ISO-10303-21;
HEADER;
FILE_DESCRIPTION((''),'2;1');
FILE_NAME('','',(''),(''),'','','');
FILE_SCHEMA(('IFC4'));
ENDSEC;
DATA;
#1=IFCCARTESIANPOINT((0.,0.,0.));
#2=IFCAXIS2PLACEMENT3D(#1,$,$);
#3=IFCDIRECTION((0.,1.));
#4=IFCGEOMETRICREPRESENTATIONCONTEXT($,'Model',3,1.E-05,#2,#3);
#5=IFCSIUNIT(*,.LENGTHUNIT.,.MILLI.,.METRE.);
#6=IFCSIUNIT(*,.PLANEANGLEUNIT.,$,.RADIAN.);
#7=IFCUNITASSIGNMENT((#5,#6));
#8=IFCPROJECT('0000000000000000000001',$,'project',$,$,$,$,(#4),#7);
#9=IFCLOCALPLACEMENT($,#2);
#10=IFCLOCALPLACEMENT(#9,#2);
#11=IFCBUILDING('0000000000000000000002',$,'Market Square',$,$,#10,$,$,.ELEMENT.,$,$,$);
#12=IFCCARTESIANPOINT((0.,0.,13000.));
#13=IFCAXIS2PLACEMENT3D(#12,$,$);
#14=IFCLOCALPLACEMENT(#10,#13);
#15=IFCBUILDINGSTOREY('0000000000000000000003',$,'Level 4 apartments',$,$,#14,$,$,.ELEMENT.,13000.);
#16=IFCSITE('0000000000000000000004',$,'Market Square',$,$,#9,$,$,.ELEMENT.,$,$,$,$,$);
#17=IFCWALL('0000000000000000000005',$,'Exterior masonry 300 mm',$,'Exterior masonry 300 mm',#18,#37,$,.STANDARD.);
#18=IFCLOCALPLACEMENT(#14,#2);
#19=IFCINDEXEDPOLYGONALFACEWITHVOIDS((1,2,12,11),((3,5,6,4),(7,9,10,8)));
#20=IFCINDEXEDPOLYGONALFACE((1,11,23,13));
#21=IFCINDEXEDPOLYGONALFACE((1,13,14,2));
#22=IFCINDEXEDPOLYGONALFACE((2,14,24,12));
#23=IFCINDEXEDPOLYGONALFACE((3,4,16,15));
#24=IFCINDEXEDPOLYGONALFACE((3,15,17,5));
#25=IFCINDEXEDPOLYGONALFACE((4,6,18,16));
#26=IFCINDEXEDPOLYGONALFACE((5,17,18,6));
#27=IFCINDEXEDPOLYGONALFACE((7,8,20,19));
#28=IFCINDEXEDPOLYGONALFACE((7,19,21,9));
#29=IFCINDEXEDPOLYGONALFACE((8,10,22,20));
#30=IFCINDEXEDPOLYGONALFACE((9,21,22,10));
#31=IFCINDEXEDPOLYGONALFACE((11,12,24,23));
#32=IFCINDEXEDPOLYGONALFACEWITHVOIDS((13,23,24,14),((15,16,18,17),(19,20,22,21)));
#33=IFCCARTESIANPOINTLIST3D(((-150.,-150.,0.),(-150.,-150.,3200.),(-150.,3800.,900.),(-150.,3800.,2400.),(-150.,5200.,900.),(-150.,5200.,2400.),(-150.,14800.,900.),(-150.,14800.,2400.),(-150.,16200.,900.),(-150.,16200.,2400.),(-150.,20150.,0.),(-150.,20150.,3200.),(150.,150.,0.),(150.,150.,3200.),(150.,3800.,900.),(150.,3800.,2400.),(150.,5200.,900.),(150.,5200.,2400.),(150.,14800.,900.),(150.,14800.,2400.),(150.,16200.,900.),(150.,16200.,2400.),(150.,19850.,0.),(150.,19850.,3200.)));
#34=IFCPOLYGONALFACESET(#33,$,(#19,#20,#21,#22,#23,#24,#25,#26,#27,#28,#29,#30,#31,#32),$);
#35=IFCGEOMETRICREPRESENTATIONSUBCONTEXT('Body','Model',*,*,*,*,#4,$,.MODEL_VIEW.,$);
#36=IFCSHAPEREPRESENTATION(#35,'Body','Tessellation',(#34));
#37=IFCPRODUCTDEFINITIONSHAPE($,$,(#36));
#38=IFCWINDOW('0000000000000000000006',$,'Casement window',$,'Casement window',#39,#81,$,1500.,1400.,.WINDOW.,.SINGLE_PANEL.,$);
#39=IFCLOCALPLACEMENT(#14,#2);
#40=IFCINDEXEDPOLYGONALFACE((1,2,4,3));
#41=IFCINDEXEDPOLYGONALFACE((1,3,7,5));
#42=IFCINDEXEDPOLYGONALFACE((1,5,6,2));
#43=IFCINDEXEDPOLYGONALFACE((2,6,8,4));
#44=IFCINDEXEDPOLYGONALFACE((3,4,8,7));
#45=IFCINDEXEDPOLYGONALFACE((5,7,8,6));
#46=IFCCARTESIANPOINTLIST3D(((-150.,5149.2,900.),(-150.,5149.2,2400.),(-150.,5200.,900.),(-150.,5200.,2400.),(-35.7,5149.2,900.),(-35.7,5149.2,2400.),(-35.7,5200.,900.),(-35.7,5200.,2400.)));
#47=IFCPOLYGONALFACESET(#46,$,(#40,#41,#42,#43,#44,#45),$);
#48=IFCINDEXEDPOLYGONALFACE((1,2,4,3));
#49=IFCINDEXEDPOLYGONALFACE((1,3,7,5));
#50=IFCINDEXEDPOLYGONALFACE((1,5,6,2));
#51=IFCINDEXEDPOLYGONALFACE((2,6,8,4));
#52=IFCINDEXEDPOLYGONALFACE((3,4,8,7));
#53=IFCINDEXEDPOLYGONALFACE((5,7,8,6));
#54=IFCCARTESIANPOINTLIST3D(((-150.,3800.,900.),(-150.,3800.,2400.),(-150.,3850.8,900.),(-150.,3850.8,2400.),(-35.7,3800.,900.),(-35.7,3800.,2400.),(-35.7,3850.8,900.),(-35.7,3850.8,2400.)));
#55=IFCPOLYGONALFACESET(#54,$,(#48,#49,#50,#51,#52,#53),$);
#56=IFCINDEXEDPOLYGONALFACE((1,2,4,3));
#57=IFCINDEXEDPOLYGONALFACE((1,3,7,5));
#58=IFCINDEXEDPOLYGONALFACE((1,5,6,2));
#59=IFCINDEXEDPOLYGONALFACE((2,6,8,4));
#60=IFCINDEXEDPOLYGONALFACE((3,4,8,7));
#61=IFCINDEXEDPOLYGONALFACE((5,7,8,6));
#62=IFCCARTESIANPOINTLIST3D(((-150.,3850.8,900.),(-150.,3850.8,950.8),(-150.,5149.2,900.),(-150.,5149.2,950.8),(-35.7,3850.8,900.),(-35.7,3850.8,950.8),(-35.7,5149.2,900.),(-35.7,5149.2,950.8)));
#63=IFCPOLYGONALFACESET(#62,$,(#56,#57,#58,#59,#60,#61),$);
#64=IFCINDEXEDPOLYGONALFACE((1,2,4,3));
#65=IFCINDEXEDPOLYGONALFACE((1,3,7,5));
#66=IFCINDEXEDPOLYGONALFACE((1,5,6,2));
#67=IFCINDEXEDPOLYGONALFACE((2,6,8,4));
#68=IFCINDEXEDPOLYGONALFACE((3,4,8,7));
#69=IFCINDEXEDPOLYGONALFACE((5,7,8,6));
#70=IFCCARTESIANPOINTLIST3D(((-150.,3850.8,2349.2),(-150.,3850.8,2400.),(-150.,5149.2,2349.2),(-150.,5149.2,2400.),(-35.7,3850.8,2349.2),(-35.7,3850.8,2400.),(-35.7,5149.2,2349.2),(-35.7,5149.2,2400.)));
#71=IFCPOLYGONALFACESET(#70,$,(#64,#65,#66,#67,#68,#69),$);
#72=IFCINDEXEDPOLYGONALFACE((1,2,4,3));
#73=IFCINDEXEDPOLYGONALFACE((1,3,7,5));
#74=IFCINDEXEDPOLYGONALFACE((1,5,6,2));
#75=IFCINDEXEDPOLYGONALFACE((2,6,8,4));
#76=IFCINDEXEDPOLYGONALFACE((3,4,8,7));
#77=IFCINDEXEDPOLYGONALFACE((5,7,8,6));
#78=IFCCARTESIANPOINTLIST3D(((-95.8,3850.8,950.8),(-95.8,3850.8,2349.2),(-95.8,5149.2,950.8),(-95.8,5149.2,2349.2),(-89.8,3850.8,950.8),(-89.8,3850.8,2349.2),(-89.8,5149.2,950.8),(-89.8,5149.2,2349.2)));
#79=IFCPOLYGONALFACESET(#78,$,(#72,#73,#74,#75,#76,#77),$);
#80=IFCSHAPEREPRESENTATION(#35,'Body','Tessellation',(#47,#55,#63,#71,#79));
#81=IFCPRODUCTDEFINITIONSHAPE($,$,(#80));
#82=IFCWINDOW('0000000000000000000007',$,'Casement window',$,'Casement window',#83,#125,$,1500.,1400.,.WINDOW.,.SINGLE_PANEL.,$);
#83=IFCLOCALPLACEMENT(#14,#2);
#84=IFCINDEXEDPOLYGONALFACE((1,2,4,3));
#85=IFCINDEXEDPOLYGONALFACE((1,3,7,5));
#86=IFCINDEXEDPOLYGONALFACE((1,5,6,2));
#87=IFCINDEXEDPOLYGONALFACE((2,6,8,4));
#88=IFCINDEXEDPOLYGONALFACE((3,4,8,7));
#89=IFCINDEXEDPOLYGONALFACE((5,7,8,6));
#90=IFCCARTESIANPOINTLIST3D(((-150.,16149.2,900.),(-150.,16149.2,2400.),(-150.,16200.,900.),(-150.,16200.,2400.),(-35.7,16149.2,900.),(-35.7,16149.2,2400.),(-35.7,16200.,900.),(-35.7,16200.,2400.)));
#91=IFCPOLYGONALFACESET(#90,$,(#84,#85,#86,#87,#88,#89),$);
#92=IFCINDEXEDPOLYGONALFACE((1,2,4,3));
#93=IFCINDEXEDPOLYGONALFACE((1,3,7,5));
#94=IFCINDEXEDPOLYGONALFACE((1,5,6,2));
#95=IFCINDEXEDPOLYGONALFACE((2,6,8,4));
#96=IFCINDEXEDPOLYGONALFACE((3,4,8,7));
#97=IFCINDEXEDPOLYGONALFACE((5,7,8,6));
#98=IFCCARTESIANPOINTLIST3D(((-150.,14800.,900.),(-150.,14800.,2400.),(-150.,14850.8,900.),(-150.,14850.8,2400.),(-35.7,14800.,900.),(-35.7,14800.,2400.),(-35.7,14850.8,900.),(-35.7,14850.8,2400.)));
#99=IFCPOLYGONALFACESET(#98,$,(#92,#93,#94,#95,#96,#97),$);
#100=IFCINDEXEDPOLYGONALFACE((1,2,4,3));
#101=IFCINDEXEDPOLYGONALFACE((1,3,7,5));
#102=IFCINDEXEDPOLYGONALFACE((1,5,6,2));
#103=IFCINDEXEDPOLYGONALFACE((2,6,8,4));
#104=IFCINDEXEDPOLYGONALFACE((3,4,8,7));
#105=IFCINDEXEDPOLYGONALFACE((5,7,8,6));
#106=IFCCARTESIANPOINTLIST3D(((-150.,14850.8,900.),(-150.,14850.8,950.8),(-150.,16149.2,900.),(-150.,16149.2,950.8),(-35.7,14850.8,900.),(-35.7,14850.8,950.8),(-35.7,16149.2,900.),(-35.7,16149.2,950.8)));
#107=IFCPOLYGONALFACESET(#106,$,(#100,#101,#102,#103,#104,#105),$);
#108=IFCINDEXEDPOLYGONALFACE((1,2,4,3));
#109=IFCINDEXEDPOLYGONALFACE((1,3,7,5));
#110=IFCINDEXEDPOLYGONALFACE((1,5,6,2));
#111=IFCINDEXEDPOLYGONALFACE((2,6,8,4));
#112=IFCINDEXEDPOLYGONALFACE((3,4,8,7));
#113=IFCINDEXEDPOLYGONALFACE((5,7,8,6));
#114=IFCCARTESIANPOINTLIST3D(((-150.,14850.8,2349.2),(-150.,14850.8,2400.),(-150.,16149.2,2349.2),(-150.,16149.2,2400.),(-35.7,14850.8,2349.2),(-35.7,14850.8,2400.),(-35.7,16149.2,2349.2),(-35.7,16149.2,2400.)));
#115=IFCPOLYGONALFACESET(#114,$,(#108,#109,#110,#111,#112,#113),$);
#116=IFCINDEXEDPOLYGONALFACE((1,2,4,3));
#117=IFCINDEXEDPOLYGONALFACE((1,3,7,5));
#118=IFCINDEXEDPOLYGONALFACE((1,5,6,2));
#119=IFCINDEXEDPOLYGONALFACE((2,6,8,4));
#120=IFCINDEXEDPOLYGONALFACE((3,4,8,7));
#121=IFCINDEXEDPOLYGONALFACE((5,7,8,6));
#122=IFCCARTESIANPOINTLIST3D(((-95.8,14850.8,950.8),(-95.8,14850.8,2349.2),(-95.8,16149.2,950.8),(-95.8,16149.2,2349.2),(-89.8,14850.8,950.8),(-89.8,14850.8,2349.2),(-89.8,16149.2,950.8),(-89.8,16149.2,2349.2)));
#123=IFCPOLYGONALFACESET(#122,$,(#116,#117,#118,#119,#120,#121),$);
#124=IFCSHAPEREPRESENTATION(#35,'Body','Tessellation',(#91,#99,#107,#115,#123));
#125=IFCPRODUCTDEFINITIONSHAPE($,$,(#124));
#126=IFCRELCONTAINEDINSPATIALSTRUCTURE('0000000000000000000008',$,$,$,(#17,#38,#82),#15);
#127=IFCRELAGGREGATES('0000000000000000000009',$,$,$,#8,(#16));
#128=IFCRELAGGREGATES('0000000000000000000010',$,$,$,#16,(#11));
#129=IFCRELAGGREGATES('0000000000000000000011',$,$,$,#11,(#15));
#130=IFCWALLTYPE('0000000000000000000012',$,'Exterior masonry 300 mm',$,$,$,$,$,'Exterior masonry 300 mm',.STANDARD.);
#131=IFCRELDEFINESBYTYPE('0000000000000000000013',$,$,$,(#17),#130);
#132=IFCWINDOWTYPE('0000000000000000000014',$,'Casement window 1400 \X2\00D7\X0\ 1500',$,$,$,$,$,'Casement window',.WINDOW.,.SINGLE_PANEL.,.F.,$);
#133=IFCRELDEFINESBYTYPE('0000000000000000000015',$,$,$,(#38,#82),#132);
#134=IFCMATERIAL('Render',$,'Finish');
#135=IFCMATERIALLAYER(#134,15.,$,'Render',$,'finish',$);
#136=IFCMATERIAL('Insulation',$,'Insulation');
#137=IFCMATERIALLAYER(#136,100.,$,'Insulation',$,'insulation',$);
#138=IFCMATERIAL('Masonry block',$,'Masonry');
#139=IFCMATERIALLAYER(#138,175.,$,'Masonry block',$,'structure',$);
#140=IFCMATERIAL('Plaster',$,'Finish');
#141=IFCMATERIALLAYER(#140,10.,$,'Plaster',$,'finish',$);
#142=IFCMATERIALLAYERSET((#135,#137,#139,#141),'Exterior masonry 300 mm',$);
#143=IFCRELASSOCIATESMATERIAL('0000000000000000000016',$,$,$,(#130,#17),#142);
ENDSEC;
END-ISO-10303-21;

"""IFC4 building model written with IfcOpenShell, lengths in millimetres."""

from ifc_helpers import new_model, si_unit, direction, frame, origin, origin_with_axes, place, context, subcontext, project, spatial, polyline, outline, extrude, material, layer, layer_set, layer_usage, type_object, element, fill, save


model = new_model("IFC4")

# Units and contexts
model_context = context("Model", 3, precision=1e-05, world=origin(), true_north=direction((0.0, 1.0)))
body_context = subcontext(model_context, "Body", "Model", "MODEL_VIEW")
ifc_project = project(units=[si_unit("LENGTHUNIT", "METRE", prefix="MILLI"), si_unit("PLANEANGLEUNIT", "RADIAN")], contexts=[model_context])

# Site, building, storey
site_placement = place(None, origin())
site = spatial("IfcSite", under=ifc_project, at=site_placement, Name="Market Square", CompositionType="ELEMENT")
building_placement = place(site_placement, origin())
building = spatial("IfcBuilding", under=site, at=building_placement, Name="Market Square", CompositionType="ELEMENT")
storey_placement = place(building_placement, frame((0.0, 0.0, 13000.0)))
storey = spatial("IfcBuildingStorey", under=building, at=storey_placement, Name="Level 4 apartments", CompositionType="ELEMENT", Elevation=13000.0)

# Wall, openings, windows
ifc_material_1 = material(Name="Render", Category="Finish")
ifc_layer_1 = layer(ifc_material_1, 15.0, Name="Render", Category="finish")
ifc_material_2 = material(Name="Insulation", Category="Insulation")
ifc_layer_2 = layer(ifc_material_2, 100.0, Name="Insulation", Category="insulation")
ifc_material_3 = material(Name="Masonry block", Category="Masonry")
ifc_layer_3 = layer(ifc_material_3, 175.0, Name="Masonry block", Category="structure")
ifc_material_4 = material(Name="Plaster", Category="Finish")
ifc_layer_4 = layer(ifc_material_4, 10.0, Name="Plaster", Category="finish")
ifc_layer_set_1 = layer_set([ifc_layer_1, ifc_layer_2, ifc_layer_3, ifc_layer_4], Name="Exterior masonry 300 mm")
ifc_layer_usage_1 = layer_usage(ifc_layer_set_1, "AXIS2", "POSITIVE", -150.0)
wall_type_1 = type_object("IfcWallType", Name="Exterior masonry 300 mm", ElementType="Exterior masonry 300 mm", PredefinedType="STANDARD", material=ifc_layer_set_1)
wall_1_placement = place(storey_placement, frame((0.0, 20000.0, 0.0), z_axis=(0.0, 0.0, 1.0), x_axis=(0.0, -1.0, 0.0)))
wall_1 = element("IfcWall", 1, at=wall_1_placement, inside=storey, type_object=wall_type_1, material=ifc_layer_usage_1, Name="Exterior masonry 300 mm", ObjectType="Exterior masonry 300 mm", PredefinedType="STANDARD", context=body_context, shape_type="SweptSolid", body=[
    extrude(outline(polyline([(-150.0, -150.0), (20150.0, -150.0), (19850.0, 150.0), (150.0, 150.0), (-150.0, -150.0)])), origin(), (0.0, 0.0, 1.0), 3200.0),
])
opening_1_placement = place(wall_1_placement, frame((14800.0, 0.0, 900.0), z_axis=(0.0, 0.0, 1.0), x_axis=(1.0, 0.0, 0.0)))
opening_1 = element("IfcOpeningElement", 2, at=opening_1_placement, cuts=wall_1, PredefinedType="OPENING", context=body_context, shape_type="SweptSolid", body=[
    extrude(outline(polyline([(0.0, -160.0), (1400.0, -160.0), (1400.0, 160.0), (0.0, 160.0), (0.0, -160.0)])), origin(), (0.0, 0.0, 1.0), 1500.0),
])
opening_2_placement = place(wall_1_placement, frame((3800.0, 0.0, 900.0), z_axis=(0.0, 0.0, 1.0), x_axis=(1.0, 0.0, 0.0)))
opening_2 = element("IfcOpeningElement", 3, at=opening_2_placement, cuts=wall_1, PredefinedType="OPENING", context=body_context, shape_type="SweptSolid", body=[
    extrude(outline(polyline([(0.0, -160.0), (1400.0, -160.0), (1400.0, 160.0), (0.0, 160.0), (0.0, -160.0)])), origin(), (0.0, 0.0, 1.0), 1500.0),
])
window_type = type_object("IfcWindowType", Name="Casement window 1400 × 1500", ElementType="Casement window", ParameterTakesPrecedence=False, PartitioningType="SINGLE_PANEL", PredefinedType="WINDOW")
window_1_placement = place(opening_1_placement, origin_with_axes())
window_1 = element("IfcWindow", 4, at=window_1_placement, inside=storey, type_object=window_type, Name="Casement window", ObjectType="Casement window", OverallHeight=1500.0, OverallWidth=1400.0, PartitioningType="SINGLE_PANEL", PredefinedType="WINDOW", context=body_context, shape_type="SweptSolid", body=[
    extrude(outline(polyline([(0.0, -150.0), (50.8, -150.0), (50.8, -35.7), (0.0, -35.7), (0.0, -150.0)])), origin(), (0.0, 0.0, 1.0), 1500.0),
    extrude(outline(polyline([(1349.2, -150.0), (1400.0, -150.0), (1400.0, -35.7), (1349.2, -35.7), (1349.2, -150.0)])), origin(), (0.0, 0.0, 1.0), 1500.0),
    extrude(outline(polyline([(50.8, -150.0), (1349.2, -150.0), (1349.2, -35.7), (50.8, -35.7), (50.8, -150.0)])), origin(), (0.0, 0.0, 1.0), 50.8),
    extrude(outline(polyline([(50.8, -150.0), (1349.2, -150.0), (1349.2, -35.7), (50.8, -35.7), (50.8, -150.0)])), frame((0.0, 0.0, 1449.2)), (0.0, 0.0, 1.0), 50.8),
    extrude(outline(polyline([(50.8, -95.8), (1349.2, -95.8), (1349.2, -89.8), (50.8, -89.8), (50.8, -95.8)])), frame((0.0, 0.0, 50.8)), (0.0, 0.0, 1.0), 1398.4),
])
fill(opening_1, window_1)
window_2_placement = place(opening_2_placement, origin_with_axes())
window_2 = element("IfcWindow", 5, at=window_2_placement, inside=storey, type_object=window_type, Name="Casement window", ObjectType="Casement window", OverallHeight=1500.0, OverallWidth=1400.0, PartitioningType="SINGLE_PANEL", PredefinedType="WINDOW", context=body_context, shape_type="SweptSolid", body=[
    extrude(outline(polyline([(0.0, -150.0), (50.8, -150.0), (50.8, -35.7), (0.0, -35.7), (0.0, -150.0)])), origin(), (0.0, 0.0, 1.0), 1500.0),
    extrude(outline(polyline([(1349.2, -150.0), (1400.0, -150.0), (1400.0, -35.7), (1349.2, -35.7), (1349.2, -150.0)])), origin(), (0.0, 0.0, 1.0), 1500.0),
    extrude(outline(polyline([(50.8, -150.0), (1349.2, -150.0), (1349.2, -35.7), (50.8, -35.7), (50.8, -150.0)])), origin(), (0.0, 0.0, 1.0), 50.8),
    extrude(outline(polyline([(50.8, -150.0), (1349.2, -150.0), (1349.2, -35.7), (50.8, -35.7), (50.8, -150.0)])), frame((0.0, 0.0, 1449.2)), (0.0, 0.0, 1.0), 50.8),
    extrude(outline(polyline([(50.8, -95.8), (1349.2, -95.8), (1349.2, -89.8), (50.8, -89.8), (50.8, -95.8)])), frame((0.0, 0.0, 50.8)), (0.0, 0.0, 1.0), 1398.4),
])
fill(opening_2, window_2)

save(model, "model.ifc")
